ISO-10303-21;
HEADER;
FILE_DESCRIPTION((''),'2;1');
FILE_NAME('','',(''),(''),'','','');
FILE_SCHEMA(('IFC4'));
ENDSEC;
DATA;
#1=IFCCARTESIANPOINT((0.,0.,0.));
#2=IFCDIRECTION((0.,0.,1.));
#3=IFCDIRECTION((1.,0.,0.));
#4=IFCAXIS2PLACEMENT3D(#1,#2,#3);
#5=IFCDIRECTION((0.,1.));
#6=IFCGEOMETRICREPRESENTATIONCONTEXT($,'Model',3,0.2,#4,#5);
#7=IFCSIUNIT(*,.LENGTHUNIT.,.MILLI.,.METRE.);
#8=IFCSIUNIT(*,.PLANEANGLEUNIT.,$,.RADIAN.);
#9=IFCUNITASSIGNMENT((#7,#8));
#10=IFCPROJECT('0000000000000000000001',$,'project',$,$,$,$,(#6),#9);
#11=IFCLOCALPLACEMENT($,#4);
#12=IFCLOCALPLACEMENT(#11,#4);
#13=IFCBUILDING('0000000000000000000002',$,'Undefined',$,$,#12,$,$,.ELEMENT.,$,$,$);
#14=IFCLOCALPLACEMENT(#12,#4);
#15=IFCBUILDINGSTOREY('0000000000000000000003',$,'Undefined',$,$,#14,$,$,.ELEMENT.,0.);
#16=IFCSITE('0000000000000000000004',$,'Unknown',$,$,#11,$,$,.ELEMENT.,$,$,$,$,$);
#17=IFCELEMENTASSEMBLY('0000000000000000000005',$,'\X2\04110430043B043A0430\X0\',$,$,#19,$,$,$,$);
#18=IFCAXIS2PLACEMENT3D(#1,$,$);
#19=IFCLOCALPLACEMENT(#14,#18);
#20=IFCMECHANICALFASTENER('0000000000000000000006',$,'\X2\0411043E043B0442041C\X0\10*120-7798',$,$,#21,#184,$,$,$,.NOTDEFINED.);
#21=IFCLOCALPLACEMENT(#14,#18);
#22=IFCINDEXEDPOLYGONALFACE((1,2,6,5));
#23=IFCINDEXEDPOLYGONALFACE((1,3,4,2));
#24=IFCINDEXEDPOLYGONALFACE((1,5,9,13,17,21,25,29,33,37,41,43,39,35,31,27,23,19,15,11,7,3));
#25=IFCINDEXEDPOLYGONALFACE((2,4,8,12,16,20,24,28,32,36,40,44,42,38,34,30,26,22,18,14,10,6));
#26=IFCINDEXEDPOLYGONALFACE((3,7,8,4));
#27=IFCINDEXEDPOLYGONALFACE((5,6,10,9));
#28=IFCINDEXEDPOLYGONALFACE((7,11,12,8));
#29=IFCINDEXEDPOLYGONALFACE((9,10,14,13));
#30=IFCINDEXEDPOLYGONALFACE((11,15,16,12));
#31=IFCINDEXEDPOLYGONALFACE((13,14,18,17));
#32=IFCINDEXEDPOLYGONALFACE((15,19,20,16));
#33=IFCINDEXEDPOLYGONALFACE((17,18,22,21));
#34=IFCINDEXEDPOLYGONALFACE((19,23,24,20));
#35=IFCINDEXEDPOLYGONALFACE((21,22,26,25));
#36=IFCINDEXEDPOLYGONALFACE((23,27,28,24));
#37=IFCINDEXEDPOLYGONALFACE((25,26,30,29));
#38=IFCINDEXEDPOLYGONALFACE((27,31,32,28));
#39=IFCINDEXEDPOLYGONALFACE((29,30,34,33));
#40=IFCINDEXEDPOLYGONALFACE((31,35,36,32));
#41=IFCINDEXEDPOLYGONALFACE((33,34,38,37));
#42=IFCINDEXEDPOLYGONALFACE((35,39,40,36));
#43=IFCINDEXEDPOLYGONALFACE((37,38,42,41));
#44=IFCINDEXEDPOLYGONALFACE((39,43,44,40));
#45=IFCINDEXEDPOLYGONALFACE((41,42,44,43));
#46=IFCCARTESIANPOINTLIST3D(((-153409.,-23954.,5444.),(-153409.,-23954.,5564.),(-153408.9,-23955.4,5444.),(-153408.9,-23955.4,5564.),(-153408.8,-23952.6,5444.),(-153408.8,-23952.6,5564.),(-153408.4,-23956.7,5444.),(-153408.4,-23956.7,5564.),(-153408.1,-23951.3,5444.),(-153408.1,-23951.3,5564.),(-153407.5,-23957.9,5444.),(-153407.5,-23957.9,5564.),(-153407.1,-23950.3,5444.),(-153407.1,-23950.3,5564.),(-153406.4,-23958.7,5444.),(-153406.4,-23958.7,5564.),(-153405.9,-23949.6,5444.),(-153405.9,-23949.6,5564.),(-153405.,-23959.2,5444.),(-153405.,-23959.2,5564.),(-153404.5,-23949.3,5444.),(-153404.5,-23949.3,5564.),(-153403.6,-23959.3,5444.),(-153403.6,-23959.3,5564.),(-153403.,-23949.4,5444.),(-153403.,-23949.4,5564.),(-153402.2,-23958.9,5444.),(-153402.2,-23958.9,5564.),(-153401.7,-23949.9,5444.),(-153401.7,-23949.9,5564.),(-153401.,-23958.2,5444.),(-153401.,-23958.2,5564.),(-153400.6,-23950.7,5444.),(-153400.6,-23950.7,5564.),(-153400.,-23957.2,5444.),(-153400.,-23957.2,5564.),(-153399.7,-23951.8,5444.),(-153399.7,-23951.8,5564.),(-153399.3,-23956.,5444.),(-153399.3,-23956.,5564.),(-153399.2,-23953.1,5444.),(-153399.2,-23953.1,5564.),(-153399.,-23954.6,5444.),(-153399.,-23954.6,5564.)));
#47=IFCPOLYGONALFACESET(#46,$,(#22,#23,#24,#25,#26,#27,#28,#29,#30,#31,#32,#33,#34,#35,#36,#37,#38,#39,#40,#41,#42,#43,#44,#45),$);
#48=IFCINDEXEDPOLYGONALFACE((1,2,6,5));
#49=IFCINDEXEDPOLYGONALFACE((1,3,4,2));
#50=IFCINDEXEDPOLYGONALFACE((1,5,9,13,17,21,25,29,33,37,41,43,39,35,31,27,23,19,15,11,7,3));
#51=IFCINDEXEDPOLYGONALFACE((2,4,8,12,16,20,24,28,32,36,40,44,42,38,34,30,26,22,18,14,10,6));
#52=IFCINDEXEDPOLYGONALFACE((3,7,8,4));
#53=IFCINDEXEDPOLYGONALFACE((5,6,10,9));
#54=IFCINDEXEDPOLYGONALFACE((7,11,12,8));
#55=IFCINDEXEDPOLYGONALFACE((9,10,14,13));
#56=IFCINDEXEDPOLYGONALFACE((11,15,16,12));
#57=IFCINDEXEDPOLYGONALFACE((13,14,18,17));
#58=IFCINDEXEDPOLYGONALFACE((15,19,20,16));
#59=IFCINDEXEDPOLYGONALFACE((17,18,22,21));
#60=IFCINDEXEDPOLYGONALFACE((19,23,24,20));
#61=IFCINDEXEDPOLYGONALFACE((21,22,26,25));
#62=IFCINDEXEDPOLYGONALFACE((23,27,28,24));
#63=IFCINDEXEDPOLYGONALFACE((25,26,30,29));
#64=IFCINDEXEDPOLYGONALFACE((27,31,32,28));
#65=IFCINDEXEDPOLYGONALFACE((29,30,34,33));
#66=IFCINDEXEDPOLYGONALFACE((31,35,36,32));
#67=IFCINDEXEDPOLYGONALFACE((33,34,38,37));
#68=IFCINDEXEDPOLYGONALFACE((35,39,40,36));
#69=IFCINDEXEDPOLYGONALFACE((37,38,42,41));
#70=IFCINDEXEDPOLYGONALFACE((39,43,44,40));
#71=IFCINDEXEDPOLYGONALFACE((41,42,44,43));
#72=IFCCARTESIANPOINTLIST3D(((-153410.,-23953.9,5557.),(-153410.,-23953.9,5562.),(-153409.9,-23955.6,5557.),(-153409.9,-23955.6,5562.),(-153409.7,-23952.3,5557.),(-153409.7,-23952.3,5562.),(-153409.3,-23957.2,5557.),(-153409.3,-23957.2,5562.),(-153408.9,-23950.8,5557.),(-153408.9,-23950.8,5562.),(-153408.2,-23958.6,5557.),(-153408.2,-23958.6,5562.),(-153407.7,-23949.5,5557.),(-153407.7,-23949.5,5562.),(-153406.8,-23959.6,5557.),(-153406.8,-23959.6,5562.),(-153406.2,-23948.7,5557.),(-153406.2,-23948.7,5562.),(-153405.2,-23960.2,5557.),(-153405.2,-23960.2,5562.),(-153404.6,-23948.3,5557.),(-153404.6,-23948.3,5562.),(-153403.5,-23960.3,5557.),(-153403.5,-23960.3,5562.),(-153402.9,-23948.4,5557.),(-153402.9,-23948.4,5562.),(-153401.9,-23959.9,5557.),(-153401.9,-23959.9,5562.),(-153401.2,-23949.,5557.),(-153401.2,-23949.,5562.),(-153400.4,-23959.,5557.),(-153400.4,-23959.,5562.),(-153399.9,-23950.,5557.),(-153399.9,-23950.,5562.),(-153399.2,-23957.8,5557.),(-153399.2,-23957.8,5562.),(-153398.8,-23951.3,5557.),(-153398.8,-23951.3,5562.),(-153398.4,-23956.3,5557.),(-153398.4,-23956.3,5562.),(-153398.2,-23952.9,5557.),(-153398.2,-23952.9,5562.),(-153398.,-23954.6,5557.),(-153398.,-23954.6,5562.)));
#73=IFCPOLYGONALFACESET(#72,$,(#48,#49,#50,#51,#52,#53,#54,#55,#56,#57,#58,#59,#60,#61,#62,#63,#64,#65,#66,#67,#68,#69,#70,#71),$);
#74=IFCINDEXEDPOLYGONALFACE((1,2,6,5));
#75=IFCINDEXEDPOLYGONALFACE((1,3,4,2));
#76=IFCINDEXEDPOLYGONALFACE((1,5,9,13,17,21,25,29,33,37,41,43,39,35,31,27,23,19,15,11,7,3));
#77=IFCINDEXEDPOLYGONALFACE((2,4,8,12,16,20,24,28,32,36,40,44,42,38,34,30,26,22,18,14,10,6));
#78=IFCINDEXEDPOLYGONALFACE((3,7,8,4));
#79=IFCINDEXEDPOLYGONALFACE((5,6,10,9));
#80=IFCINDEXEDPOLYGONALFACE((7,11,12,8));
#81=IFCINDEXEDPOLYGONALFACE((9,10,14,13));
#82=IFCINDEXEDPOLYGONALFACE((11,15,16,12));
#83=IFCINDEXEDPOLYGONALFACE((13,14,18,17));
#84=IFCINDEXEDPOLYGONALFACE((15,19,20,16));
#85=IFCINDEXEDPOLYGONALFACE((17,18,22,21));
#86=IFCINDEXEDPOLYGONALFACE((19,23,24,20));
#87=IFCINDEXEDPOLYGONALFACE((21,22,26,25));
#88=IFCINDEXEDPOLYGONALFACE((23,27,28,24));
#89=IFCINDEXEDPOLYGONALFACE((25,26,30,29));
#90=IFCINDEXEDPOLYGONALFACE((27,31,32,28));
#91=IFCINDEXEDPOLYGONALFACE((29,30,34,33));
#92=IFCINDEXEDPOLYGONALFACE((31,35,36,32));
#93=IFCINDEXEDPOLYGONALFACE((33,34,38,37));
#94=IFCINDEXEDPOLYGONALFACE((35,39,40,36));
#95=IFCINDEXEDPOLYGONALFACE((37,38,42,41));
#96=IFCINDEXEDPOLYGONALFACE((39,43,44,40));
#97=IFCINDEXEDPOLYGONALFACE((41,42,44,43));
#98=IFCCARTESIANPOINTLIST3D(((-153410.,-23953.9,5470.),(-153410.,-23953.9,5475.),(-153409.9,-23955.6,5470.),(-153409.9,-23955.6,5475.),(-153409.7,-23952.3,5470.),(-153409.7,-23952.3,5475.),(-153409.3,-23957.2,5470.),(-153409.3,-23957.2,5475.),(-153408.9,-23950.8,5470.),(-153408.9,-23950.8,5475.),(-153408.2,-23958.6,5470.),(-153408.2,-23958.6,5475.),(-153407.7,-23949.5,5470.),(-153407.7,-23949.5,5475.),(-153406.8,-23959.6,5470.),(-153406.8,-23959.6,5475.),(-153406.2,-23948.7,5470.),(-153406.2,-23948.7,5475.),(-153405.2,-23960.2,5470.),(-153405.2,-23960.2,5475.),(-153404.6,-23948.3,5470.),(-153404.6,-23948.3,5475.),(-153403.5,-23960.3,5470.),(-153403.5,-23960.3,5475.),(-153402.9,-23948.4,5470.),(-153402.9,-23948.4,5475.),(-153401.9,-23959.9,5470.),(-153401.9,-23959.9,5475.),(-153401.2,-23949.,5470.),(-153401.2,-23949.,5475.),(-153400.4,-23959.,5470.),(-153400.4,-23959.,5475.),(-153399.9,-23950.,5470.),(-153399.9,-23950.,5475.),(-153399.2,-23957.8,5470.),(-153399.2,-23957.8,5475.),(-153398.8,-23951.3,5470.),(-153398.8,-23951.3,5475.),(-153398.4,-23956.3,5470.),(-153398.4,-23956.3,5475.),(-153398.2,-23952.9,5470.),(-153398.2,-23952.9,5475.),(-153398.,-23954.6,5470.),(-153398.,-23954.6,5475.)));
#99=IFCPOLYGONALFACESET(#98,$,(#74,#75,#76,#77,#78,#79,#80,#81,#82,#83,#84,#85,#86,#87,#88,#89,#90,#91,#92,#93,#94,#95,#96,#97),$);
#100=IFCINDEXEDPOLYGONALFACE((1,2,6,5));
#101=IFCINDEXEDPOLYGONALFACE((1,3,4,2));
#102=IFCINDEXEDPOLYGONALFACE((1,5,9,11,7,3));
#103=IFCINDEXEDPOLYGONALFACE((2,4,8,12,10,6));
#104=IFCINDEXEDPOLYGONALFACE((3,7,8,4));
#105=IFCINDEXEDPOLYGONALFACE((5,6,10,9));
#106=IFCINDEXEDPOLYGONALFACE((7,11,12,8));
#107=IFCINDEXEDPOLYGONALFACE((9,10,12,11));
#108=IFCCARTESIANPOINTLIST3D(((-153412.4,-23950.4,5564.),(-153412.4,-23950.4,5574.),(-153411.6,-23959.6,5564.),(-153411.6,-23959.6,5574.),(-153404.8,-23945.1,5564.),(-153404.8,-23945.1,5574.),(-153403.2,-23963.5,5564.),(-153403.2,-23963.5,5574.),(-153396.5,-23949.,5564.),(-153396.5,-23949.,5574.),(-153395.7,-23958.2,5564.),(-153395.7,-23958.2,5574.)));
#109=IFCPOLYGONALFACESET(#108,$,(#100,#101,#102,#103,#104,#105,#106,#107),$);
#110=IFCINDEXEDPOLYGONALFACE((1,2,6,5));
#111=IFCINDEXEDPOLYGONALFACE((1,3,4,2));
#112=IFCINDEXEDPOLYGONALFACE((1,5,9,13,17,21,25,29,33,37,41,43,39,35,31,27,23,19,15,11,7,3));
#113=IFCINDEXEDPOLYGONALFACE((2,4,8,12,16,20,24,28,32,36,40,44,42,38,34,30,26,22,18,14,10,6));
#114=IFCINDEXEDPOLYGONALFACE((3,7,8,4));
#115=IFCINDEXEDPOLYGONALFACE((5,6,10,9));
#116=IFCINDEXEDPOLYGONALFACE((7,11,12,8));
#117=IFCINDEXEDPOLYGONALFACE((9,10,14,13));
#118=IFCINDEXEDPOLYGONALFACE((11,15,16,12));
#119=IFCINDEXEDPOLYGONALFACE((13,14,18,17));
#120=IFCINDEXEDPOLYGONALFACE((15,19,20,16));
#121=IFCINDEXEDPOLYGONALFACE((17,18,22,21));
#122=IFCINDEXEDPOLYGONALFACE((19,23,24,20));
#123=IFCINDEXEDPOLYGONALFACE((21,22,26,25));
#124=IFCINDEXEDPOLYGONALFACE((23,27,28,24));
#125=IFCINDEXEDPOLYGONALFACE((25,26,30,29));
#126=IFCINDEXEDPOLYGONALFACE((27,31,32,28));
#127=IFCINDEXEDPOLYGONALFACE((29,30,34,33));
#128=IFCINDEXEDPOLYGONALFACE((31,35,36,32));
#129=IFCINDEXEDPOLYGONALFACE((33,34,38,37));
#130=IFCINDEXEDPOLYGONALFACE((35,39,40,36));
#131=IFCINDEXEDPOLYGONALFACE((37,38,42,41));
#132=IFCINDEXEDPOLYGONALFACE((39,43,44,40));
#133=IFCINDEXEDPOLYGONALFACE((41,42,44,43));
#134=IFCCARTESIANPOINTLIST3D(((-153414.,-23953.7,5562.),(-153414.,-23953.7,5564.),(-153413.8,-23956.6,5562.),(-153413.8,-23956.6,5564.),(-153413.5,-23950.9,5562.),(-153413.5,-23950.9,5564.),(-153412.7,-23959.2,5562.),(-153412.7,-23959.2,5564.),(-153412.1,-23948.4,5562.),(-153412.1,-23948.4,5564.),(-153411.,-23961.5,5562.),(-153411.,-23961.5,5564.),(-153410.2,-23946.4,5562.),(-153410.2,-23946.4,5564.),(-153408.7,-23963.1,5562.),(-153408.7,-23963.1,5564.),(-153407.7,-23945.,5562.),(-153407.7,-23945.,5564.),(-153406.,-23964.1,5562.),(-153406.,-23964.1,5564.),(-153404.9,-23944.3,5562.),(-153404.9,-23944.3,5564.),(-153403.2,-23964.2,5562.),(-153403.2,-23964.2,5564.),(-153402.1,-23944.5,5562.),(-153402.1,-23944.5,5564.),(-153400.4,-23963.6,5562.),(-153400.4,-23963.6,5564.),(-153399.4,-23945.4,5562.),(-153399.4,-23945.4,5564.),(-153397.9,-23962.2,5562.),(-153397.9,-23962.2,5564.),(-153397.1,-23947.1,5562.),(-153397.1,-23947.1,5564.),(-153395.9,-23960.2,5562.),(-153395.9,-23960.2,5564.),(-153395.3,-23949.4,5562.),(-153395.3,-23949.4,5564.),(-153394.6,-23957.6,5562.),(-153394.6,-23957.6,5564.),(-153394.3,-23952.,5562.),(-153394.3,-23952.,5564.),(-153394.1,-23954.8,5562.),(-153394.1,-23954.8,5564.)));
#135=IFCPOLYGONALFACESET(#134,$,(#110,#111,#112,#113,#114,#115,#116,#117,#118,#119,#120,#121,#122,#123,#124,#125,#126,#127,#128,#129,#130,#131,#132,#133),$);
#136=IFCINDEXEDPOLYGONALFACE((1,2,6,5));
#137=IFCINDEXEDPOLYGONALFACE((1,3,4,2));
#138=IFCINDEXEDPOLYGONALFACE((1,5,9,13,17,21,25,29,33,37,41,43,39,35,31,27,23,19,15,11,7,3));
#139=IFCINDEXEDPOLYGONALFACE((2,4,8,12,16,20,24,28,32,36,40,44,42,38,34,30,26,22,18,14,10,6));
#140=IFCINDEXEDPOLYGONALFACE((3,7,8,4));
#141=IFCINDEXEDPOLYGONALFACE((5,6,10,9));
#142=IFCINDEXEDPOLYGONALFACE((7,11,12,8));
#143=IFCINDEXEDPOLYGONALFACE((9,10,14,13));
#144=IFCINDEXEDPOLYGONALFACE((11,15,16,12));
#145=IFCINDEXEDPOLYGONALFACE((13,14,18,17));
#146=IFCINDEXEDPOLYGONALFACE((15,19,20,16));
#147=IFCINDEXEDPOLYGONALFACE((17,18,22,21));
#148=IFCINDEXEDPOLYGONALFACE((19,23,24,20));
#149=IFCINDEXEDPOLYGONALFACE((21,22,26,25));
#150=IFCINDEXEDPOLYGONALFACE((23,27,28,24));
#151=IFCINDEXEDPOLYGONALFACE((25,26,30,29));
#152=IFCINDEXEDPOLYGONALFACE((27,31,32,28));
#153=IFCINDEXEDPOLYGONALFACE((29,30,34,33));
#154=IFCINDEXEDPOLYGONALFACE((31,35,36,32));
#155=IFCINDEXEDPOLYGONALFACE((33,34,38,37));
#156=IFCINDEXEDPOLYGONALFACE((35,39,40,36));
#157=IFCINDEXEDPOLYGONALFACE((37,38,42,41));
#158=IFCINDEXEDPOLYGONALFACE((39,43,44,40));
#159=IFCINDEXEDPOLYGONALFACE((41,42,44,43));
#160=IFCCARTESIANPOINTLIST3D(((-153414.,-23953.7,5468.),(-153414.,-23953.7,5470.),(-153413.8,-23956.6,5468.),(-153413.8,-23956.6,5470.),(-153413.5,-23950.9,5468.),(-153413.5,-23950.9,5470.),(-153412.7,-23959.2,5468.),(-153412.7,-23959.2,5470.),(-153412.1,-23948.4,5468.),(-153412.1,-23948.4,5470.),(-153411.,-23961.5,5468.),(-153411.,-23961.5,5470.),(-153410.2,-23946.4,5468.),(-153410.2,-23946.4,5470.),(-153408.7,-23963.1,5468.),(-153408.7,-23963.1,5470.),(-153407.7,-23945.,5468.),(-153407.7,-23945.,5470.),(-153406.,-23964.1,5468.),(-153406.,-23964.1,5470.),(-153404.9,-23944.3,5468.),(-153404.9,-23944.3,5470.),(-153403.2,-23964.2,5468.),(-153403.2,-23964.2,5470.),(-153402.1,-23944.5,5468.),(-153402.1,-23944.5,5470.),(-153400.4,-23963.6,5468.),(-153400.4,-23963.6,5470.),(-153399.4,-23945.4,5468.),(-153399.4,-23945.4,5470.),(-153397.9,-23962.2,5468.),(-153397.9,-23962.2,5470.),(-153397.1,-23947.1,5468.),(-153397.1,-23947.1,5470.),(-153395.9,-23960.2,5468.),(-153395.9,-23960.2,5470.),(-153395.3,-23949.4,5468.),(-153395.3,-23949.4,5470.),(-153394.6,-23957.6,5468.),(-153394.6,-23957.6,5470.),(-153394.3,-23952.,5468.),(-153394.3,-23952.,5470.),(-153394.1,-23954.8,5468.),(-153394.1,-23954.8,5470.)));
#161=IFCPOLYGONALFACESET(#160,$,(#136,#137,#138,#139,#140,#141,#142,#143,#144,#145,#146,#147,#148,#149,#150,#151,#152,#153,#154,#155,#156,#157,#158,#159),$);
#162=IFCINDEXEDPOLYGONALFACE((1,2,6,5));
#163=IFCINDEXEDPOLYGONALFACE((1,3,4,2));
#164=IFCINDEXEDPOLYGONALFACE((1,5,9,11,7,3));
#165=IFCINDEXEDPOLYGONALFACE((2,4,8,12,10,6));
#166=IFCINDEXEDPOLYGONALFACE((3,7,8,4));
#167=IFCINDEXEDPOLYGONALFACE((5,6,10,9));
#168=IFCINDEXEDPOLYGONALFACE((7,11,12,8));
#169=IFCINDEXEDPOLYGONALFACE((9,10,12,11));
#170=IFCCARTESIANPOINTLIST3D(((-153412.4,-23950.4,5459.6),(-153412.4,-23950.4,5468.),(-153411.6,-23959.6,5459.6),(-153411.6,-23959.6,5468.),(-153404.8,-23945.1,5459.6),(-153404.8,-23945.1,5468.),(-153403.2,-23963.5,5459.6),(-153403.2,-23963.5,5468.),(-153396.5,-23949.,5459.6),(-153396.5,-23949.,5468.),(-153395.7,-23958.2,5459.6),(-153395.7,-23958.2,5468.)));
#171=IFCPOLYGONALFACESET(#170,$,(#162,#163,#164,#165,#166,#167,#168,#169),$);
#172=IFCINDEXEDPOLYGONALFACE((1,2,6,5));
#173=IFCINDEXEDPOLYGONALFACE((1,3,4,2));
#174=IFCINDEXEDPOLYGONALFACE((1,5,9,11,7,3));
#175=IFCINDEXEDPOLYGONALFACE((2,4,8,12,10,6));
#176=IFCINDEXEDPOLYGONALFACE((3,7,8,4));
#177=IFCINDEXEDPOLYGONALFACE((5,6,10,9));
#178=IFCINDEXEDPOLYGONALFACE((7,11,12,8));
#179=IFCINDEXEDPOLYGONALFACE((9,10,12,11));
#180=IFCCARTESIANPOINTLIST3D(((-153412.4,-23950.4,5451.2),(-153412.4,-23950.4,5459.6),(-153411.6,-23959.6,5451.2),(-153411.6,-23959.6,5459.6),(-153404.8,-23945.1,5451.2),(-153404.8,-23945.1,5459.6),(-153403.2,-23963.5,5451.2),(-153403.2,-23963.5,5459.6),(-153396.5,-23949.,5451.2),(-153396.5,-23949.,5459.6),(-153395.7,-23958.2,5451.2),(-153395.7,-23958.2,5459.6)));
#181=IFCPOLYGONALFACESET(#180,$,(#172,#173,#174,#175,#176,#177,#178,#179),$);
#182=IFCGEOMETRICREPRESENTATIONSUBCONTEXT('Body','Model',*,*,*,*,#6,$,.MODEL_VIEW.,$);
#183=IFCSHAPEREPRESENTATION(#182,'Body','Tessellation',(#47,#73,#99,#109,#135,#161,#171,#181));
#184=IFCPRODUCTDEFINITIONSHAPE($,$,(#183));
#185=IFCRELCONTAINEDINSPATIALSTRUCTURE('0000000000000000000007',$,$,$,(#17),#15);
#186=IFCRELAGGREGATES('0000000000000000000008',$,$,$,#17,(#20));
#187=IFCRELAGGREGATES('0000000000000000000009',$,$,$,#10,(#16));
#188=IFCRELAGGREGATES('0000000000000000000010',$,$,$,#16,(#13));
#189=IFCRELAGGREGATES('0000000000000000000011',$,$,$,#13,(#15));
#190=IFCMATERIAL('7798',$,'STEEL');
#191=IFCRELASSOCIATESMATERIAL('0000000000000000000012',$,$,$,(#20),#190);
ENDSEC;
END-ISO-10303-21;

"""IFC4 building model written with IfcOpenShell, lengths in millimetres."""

from ifc_helpers import new_model, si_unit, direction, frame, origin_with_axes, place, context, subcontext, project, spatial, line, arc, indexed_curve, outline, extrude, source, transform, mapped, material, element, aggregate, save


model = new_model("IFC4")

# Units and contexts
model_context = context("Model", 3, precision=0.2, world=origin_with_axes(), true_north=direction((0.0, 1.0)))
body_context = subcontext(model_context, "Body", "Model", "MODEL_VIEW")
ifc_project = project(units=[si_unit("LENGTHUNIT", "METRE", prefix="MILLI"), si_unit("PLANEANGLEUNIT", "RADIAN")], contexts=[model_context])

# Site, building, storey
site_placement = place(None, origin_with_axes())
site = spatial("IfcSite", under=ifc_project, at=site_placement, Name="Unknown", CompositionType="ELEMENT")
building_placement = place(site_placement, origin_with_axes())
building = spatial("IfcBuilding", under=site, at=building_placement, Name="Undefined", CompositionType="ELEMENT")
storey_placement = place(building_placement, origin_with_axes())
storey = spatial("IfcBuildingStorey", under=building, at=storey_placement, Name="Undefined", CompositionType="ELEMENT", Elevation=0.0)

# Element assembly
assembly_1_placement = place(storey_placement, frame((-153552.0, -23967.1, 5606.0), z_axis=(0.996285, 0.086114, 0.0), x_axis=(0.0, 0.0, -1.0)))
assembly_1 = element("IfcElementAssembly", 1, at=assembly_1_placement, inside=storey, Name="Балка")

# Shared definitions
ifc_material_1 = material(Name="7798", Category="STEEL")

# Mechanical fastener
shared_shape_1 = source(origin_with_axes(), body_context, "Body", "SweptSolid", [
    extrude(outline(indexed_curve([(5.0, 0.0), (0.0, 5.0), (-5.0, 0.0), (0.0, -5.0)], segments=[arc(1, 2, 3), arc(3, 4, 1)])), frame((0.0, 0.0, 7.0), z_axis=(0.0, 0.0, -1.0), x_axis=(0.0, 1.0, 0.0)), (0.0, 0.0, 1.0), 120.0),
    extrude(outline(indexed_curve([(6.0, 0.0), (0.0, 6.0), (-6.0, 0.0), (0.0, -6.0)], segments=[arc(1, 2, 3), arc(3, 4, 1)])), frame((0.0, 0.0, 5.0), z_axis=(0.0, 0.0, -1.0), x_axis=(0.0, 1.0, 0.0)), (0.0, 0.0, 1.0), 5.0),
    extrude(outline(indexed_curve([(6.0, 0.0), (0.0, 6.0), (-6.0, 0.0), (0.0, -6.0)], segments=[arc(1, 2, 3), arc(3, 4, 1)])), frame((0.0, 0.0, -82.0), z_axis=(0.0, 0.0, -1.0), x_axis=(0.0, 1.0, 0.0)), (0.0, 0.0, 1.0), 5.0),
    extrude(outline(indexed_curve([(9.2, 0.0), (4.6, 8.0), (-4.6, 8.0), (-9.2, 0.0), (-4.6, -8.0), (4.6, -8.0)], segments=[line(1, 2, 3, 4, 5, 6, 1)])), frame((0.0, 0.0, 17.0), z_axis=(0.0, 0.0, -1.0), x_axis=(0.0, 1.0, 0.0)), (0.0, 0.0, 1.0), 10.0),
    extrude(outline(indexed_curve([(10.0, 0.0), (0.0, 10.0), (-10.0, 0.0), (0.0, -10.0)], segments=[arc(1, 2, 3), arc(3, 4, 1)])), frame((0.0, 0.0, 7.0), z_axis=(0.0, 0.0, -1.0), x_axis=(0.0, 1.0, 0.0)), (0.0, 0.0, 1.0), 2.0),
    extrude(outline(indexed_curve([(10.0, 0.0), (0.0, 10.0), (-10.0, 0.0), (0.0, -10.0)], segments=[arc(1, 2, 3), arc(3, 4, 1)])), frame((0.0, 0.0, -87.0), z_axis=(0.0, 0.0, -1.0), x_axis=(0.0, 1.0, 0.0)), (0.0, 0.0, 1.0), 2.0),
    extrude(outline(indexed_curve([(9.2, 0.0), (4.6, 8.0), (-4.6, 8.0), (-9.2, 0.0), (-4.6, -8.0), (4.6, -8.0)], segments=[line(1, 2, 3, 4, 5, 6, 1)])), frame((0.0, 0.0, -89.0), z_axis=(0.0, 0.0, -1.0), x_axis=(0.0, 1.0, 0.0)), (0.0, 0.0, 1.0), 8.4),
    extrude(outline(indexed_curve([(9.2, 0.0), (4.6, 8.0), (-4.6, 8.0), (-9.2, 0.0), (-4.6, -8.0), (4.6, -8.0)], segments=[line(1, 2, 3, 4, 5, 6, 1)])), frame((0.0, 0.0, -97.4), z_axis=(0.0, 0.0, -1.0), x_axis=(0.0, 1.0, 0.0)), (0.0, 0.0, 1.0), 8.4),
])
mechanical_fastener_1_placement = place(assembly_1_placement, frame((49.0, 0.0, 148.5), z_axis=(-1.0, 0.0, 0.0), x_axis=(0.0, 0.0, -1.0)))
mechanical_fastener_1 = element("IfcMechanicalFastener", 2, at=mechanical_fastener_1_placement, material=ifc_material_1, Name="БолтМ10*120-7798", PredefinedType="NOTDEFINED", context=body_context, shape_type="MappedRepresentation", body=[
    mapped(shared_shape_1, transform((0.0, 0.0, 0.0))),
])
aggregate(assembly_1, [mechanical_fastener_1])

save(model, "model.ifc")
